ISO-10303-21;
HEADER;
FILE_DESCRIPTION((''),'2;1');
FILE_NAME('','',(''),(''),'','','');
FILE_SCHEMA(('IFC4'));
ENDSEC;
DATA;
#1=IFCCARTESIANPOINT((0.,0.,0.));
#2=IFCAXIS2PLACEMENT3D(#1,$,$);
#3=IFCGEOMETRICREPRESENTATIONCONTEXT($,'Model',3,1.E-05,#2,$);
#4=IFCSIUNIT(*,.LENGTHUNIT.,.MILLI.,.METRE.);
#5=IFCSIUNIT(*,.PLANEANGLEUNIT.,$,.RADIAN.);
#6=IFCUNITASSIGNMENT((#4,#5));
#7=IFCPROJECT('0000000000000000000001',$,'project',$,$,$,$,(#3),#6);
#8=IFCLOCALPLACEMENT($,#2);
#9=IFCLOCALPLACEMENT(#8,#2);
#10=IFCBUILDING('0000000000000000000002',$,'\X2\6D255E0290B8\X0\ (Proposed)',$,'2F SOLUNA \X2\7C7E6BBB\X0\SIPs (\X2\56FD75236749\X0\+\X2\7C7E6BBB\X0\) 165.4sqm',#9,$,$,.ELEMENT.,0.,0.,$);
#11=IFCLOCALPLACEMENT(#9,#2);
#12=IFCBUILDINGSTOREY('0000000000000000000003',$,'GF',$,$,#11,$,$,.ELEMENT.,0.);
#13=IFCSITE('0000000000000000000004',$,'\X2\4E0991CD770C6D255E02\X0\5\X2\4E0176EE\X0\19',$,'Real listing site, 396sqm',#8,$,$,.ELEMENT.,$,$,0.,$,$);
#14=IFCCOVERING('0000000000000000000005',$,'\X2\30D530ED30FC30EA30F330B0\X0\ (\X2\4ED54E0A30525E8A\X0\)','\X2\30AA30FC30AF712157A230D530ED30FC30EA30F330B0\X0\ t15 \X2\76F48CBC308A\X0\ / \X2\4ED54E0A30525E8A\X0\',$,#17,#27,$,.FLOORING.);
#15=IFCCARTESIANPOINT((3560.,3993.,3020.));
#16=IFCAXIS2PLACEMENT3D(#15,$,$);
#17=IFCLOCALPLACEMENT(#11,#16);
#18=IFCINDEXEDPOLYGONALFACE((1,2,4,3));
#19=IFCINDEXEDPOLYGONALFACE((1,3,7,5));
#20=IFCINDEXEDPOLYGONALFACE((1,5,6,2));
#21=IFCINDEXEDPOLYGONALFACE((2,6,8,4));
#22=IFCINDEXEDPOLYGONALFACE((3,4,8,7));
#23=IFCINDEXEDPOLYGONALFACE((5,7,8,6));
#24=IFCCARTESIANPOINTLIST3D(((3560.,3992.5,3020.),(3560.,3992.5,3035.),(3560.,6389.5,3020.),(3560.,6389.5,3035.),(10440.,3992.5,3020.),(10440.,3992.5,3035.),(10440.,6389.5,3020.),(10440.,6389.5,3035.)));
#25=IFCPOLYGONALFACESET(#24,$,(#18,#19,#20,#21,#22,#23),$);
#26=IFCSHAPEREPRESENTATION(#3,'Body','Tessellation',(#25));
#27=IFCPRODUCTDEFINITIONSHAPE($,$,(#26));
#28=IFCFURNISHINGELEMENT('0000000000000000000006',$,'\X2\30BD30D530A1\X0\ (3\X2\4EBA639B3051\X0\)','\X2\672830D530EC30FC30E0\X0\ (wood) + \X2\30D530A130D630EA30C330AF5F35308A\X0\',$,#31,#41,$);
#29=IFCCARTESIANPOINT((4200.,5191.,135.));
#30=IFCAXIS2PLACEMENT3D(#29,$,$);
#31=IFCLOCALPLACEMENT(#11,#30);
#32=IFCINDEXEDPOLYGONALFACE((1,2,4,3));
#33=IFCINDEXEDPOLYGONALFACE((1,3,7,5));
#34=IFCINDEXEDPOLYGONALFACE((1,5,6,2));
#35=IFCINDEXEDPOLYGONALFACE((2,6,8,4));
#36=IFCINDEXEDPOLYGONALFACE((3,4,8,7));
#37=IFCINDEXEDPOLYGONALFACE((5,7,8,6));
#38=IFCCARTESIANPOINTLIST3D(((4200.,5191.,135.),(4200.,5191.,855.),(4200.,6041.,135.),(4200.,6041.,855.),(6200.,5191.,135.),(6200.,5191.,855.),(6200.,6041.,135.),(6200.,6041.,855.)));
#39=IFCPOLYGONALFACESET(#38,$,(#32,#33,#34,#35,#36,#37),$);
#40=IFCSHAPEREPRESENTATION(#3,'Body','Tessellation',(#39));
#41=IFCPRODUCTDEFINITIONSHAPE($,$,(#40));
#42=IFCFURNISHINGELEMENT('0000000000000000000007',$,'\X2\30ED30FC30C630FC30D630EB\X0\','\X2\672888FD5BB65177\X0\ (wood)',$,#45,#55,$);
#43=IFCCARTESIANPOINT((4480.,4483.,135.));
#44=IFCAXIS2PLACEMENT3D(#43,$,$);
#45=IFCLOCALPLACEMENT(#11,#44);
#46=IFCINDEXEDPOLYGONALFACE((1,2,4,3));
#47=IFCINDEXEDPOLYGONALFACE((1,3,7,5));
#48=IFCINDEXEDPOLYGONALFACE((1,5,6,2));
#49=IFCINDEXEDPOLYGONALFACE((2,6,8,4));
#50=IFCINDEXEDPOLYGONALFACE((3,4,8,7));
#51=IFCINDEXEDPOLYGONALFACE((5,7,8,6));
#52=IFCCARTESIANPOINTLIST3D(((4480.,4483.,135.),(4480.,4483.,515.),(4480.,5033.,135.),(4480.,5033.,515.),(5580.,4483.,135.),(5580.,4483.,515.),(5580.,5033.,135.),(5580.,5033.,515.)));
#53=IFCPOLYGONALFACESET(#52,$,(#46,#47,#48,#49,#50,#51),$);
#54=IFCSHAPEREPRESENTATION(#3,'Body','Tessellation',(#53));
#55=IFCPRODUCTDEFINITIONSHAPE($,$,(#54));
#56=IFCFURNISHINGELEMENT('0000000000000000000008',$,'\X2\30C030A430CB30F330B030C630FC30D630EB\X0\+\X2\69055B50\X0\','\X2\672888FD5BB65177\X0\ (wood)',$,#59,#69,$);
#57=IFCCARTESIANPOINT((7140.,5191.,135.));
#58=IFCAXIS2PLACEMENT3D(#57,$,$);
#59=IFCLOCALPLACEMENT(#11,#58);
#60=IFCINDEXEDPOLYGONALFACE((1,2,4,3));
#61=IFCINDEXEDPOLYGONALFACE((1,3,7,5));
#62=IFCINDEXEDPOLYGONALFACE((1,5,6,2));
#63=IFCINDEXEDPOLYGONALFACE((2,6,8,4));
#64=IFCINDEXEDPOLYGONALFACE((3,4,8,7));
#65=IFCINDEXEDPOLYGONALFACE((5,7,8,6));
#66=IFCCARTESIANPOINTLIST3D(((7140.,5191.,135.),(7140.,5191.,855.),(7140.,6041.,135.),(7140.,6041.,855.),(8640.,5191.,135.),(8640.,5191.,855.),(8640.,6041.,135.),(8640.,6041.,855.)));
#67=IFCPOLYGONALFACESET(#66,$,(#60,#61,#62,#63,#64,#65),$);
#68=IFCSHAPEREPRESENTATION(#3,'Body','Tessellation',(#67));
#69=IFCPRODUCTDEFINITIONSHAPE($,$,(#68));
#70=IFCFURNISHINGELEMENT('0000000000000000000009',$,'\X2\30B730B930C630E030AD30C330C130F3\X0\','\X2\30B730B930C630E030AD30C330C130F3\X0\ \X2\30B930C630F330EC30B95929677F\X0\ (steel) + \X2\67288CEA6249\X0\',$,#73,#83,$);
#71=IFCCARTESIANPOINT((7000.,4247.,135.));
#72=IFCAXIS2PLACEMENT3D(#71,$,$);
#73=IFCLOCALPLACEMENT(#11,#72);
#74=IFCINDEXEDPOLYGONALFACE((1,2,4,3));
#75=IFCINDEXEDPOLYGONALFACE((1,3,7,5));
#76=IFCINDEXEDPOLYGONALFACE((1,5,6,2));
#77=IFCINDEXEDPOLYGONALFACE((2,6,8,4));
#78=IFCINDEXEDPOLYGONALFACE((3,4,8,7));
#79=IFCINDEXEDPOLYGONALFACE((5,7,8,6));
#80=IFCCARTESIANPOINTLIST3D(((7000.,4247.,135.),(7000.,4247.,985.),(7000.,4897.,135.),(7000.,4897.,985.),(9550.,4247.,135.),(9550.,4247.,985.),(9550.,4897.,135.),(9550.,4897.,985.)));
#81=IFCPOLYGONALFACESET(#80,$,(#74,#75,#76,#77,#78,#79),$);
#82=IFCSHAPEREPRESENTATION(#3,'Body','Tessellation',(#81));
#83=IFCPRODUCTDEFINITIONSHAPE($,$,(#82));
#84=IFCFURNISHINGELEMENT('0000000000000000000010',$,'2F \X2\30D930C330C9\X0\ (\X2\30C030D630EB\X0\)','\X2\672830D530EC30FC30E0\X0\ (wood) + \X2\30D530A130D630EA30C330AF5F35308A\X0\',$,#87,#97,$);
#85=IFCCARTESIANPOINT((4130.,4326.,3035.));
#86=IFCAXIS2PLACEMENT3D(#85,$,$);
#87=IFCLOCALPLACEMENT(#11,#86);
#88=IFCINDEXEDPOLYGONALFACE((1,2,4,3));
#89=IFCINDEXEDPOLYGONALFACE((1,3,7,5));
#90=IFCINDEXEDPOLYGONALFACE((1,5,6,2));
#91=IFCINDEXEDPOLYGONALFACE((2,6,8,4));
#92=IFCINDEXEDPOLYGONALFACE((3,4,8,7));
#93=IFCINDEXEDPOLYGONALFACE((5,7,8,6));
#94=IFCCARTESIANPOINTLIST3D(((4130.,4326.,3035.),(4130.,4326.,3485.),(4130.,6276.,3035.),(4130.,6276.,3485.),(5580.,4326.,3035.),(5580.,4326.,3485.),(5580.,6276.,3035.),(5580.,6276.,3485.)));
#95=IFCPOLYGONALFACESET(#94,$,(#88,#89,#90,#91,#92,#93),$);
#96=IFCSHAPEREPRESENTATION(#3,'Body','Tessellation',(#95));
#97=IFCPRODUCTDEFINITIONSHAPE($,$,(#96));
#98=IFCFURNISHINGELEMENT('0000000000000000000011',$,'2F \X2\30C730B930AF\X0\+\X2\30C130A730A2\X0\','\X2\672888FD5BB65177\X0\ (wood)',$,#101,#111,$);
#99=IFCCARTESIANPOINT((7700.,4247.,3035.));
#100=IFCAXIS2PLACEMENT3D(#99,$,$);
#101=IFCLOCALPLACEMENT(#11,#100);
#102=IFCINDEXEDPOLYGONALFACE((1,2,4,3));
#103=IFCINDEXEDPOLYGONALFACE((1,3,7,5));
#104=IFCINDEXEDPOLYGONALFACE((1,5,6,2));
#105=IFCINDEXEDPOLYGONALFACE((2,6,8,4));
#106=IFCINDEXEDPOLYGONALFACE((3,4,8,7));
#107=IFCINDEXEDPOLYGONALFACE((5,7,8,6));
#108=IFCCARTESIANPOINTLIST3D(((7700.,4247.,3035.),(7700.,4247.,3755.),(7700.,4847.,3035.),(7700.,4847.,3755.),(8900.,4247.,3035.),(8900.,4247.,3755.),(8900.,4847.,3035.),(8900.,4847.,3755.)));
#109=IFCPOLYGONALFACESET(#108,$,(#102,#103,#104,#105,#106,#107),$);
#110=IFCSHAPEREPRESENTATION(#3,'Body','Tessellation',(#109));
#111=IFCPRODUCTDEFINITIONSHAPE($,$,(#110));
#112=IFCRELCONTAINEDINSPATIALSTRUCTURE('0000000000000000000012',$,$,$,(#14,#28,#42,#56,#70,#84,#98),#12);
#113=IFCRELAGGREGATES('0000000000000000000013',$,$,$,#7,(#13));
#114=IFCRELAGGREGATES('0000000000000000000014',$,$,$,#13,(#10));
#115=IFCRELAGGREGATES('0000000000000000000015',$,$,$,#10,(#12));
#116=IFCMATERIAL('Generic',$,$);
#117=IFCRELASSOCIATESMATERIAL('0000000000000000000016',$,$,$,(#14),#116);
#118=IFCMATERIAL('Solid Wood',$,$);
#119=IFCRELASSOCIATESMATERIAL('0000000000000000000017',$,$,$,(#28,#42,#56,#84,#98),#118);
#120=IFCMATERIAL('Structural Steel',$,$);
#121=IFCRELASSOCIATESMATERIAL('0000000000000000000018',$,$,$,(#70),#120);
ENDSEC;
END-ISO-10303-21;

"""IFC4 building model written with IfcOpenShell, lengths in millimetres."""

from ifc_helpers import new_model, si_unit, frame, frame_2d, origin, place, context, project, spatial, rectangle, extrude, material, element, save


model = new_model("IFC4")

# Units and contexts
model_context = context("Model", 3, precision=1e-05, world=origin())
ifc_project = project(units=[si_unit("LENGTHUNIT", "METRE", prefix="MILLI"), si_unit("PLANEANGLEUNIT", "RADIAN")], contexts=[model_context])

# Site, building, storey
site_placement = place(None, origin())
site = spatial("IfcSite", under=ifc_project, at=site_placement, Name="三重県津市5丁目19", ObjectType="Real listing site, 396sqm", CompositionType="ELEMENT", RefElevation=0.0)
building_placement = place(site_placement, origin())
building = spatial("IfcBuilding", under=site, at=building_placement, Name="津市邸 (Proposed)", ObjectType="2F SOLUNA 籾殻SIPs (国産杉+籾殻) 165.4sqm", CompositionType="ELEMENT", ElevationOfRefHeight=0.0, ElevationOfTerrain=0.0)
storey_placement = place(building_placement, origin())
storey = spatial("IfcBuildingStorey", under=building, at=storey_placement, Name="GF", CompositionType="ELEMENT", Elevation=0.0)

# Shared definitions
ifc_material_1 = material(Name="Solid Wood")

# Shared definitions
ifc_material_2 = material(Name="Generic")

# Shared definitions
ifc_material_3 = material(Name="Structural Steel")

# Covering
covering_placement = place(storey_placement, frame((3560.0, 3993.0, 3020.0)))
element("IfcCovering", 1, at=covering_placement, inside=storey, material=ifc_material_2, Name="フローリング (仕上げ床)", Description="オーク無垢フローリング t15 直貼り / 仕上げ床", PredefinedType="FLOORING", context=model_context, shape_type="SweptSolid", body=[
    extrude(rectangle(XDim=6880.0, YDim=2397.0, at=frame_2d((3440.0, 1198.0))), frame((3560.0, 3993.0, 3020.0)), (0.0, 0.0, 1.0), 15.0),
])

# Furnishing elements
furnishing_1_placement = place(storey_placement, frame((4200.0, 5191.0, 135.0)))
element("IfcFurnishingElement", 2, at=furnishing_1_placement, inside=storey, material=ifc_material_1, Name="ソファ (3人掛け)", Description="木フレーム (wood) + ファブリック張り", context=model_context, shape_type="SweptSolid", body=[
    extrude(rectangle(XDim=2000.0, YDim=850.0, at=frame_2d((1000.0, 425.0))), frame((4200.0, 5191.0, 135.0)), (0.0, 0.0, 1.0), 720.0),
])
furnishing_2_placement = place(storey_placement, frame((4480.0, 4483.0, 135.0)))
element("IfcFurnishingElement", 3, at=furnishing_2_placement, inside=storey, material=ifc_material_1, Name="ローテーブル", Description="木製家具 (wood)", context=model_context, shape_type="SweptSolid", body=[
    extrude(rectangle(XDim=1100.0, YDim=550.0, at=frame_2d((550.0, 275.0))), frame((4480.0, 4483.0, 135.0)), (0.0, 0.0, 1.0), 380.0),
])
furnishing_3_placement = place(storey_placement, frame((7140.0, 5191.0, 135.0)))
element("IfcFurnishingElement", 4, at=furnishing_3_placement, inside=storey, material=ifc_material_1, Name="ダイニングテーブル+椅子", Description="木製家具 (wood)", context=model_context, shape_type="SweptSolid", body=[
    extrude(rectangle(XDim=1500.0, YDim=850.0, at=frame_2d((750.0, 425.0))), frame((7140.0, 5191.0, 135.0)), (0.0, 0.0, 1.0), 720.0),
])
furnishing_4_placement = place(storey_placement, frame((7000.0, 4247.0, 135.0)))
element("IfcFurnishingElement", 5, at=furnishing_4_placement, inside=storey, material=ifc_material_3, Name="システムキッチン", Description="システムキッチン ステンレス天板 (steel) + 木質扉", context=model_context, shape_type="SweptSolid", body=[
    extrude(rectangle(XDim=2550.0, YDim=650.0, at=frame_2d((1275.0, 325.0))), frame((7000.0, 4247.0, 135.0)), (0.0, 0.0, 1.0), 850.0),
])
furnishing_5_placement = place(storey_placement, frame((4130.0, 4326.0, 3035.0)))
element("IfcFurnishingElement", 6, at=furnishing_5_placement, inside=storey, material=ifc_material_1, Name="2F ベッド (ダブル)", Description="木フレーム (wood) + ファブリック張り", context=model_context, shape_type="SweptSolid", body=[
    extrude(rectangle(XDim=1450.0, YDim=1950.0, at=frame_2d((725.0, 975.0))), frame((4130.0, 4326.0, 3035.0)), (0.0, 0.0, 1.0), 450.0),
])
furnishing_6_placement = place(storey_placement, frame((7700.0, 4247.0, 3035.0)))
element("IfcFurnishingElement", 7, at=furnishing_6_placement, inside=storey, material=ifc_material_1, Name="2F デスク+チェア", Description="木製家具 (wood)", context=model_context, shape_type="SweptSolid", body=[
    extrude(rectangle(XDim=1200.0, YDim=600.0, at=frame_2d((600.0, 300.0))), frame((7700.0, 4247.0, 3035.0)), (0.0, 0.0, 1.0), 720.0),
])

save(model, "model.ifc")
